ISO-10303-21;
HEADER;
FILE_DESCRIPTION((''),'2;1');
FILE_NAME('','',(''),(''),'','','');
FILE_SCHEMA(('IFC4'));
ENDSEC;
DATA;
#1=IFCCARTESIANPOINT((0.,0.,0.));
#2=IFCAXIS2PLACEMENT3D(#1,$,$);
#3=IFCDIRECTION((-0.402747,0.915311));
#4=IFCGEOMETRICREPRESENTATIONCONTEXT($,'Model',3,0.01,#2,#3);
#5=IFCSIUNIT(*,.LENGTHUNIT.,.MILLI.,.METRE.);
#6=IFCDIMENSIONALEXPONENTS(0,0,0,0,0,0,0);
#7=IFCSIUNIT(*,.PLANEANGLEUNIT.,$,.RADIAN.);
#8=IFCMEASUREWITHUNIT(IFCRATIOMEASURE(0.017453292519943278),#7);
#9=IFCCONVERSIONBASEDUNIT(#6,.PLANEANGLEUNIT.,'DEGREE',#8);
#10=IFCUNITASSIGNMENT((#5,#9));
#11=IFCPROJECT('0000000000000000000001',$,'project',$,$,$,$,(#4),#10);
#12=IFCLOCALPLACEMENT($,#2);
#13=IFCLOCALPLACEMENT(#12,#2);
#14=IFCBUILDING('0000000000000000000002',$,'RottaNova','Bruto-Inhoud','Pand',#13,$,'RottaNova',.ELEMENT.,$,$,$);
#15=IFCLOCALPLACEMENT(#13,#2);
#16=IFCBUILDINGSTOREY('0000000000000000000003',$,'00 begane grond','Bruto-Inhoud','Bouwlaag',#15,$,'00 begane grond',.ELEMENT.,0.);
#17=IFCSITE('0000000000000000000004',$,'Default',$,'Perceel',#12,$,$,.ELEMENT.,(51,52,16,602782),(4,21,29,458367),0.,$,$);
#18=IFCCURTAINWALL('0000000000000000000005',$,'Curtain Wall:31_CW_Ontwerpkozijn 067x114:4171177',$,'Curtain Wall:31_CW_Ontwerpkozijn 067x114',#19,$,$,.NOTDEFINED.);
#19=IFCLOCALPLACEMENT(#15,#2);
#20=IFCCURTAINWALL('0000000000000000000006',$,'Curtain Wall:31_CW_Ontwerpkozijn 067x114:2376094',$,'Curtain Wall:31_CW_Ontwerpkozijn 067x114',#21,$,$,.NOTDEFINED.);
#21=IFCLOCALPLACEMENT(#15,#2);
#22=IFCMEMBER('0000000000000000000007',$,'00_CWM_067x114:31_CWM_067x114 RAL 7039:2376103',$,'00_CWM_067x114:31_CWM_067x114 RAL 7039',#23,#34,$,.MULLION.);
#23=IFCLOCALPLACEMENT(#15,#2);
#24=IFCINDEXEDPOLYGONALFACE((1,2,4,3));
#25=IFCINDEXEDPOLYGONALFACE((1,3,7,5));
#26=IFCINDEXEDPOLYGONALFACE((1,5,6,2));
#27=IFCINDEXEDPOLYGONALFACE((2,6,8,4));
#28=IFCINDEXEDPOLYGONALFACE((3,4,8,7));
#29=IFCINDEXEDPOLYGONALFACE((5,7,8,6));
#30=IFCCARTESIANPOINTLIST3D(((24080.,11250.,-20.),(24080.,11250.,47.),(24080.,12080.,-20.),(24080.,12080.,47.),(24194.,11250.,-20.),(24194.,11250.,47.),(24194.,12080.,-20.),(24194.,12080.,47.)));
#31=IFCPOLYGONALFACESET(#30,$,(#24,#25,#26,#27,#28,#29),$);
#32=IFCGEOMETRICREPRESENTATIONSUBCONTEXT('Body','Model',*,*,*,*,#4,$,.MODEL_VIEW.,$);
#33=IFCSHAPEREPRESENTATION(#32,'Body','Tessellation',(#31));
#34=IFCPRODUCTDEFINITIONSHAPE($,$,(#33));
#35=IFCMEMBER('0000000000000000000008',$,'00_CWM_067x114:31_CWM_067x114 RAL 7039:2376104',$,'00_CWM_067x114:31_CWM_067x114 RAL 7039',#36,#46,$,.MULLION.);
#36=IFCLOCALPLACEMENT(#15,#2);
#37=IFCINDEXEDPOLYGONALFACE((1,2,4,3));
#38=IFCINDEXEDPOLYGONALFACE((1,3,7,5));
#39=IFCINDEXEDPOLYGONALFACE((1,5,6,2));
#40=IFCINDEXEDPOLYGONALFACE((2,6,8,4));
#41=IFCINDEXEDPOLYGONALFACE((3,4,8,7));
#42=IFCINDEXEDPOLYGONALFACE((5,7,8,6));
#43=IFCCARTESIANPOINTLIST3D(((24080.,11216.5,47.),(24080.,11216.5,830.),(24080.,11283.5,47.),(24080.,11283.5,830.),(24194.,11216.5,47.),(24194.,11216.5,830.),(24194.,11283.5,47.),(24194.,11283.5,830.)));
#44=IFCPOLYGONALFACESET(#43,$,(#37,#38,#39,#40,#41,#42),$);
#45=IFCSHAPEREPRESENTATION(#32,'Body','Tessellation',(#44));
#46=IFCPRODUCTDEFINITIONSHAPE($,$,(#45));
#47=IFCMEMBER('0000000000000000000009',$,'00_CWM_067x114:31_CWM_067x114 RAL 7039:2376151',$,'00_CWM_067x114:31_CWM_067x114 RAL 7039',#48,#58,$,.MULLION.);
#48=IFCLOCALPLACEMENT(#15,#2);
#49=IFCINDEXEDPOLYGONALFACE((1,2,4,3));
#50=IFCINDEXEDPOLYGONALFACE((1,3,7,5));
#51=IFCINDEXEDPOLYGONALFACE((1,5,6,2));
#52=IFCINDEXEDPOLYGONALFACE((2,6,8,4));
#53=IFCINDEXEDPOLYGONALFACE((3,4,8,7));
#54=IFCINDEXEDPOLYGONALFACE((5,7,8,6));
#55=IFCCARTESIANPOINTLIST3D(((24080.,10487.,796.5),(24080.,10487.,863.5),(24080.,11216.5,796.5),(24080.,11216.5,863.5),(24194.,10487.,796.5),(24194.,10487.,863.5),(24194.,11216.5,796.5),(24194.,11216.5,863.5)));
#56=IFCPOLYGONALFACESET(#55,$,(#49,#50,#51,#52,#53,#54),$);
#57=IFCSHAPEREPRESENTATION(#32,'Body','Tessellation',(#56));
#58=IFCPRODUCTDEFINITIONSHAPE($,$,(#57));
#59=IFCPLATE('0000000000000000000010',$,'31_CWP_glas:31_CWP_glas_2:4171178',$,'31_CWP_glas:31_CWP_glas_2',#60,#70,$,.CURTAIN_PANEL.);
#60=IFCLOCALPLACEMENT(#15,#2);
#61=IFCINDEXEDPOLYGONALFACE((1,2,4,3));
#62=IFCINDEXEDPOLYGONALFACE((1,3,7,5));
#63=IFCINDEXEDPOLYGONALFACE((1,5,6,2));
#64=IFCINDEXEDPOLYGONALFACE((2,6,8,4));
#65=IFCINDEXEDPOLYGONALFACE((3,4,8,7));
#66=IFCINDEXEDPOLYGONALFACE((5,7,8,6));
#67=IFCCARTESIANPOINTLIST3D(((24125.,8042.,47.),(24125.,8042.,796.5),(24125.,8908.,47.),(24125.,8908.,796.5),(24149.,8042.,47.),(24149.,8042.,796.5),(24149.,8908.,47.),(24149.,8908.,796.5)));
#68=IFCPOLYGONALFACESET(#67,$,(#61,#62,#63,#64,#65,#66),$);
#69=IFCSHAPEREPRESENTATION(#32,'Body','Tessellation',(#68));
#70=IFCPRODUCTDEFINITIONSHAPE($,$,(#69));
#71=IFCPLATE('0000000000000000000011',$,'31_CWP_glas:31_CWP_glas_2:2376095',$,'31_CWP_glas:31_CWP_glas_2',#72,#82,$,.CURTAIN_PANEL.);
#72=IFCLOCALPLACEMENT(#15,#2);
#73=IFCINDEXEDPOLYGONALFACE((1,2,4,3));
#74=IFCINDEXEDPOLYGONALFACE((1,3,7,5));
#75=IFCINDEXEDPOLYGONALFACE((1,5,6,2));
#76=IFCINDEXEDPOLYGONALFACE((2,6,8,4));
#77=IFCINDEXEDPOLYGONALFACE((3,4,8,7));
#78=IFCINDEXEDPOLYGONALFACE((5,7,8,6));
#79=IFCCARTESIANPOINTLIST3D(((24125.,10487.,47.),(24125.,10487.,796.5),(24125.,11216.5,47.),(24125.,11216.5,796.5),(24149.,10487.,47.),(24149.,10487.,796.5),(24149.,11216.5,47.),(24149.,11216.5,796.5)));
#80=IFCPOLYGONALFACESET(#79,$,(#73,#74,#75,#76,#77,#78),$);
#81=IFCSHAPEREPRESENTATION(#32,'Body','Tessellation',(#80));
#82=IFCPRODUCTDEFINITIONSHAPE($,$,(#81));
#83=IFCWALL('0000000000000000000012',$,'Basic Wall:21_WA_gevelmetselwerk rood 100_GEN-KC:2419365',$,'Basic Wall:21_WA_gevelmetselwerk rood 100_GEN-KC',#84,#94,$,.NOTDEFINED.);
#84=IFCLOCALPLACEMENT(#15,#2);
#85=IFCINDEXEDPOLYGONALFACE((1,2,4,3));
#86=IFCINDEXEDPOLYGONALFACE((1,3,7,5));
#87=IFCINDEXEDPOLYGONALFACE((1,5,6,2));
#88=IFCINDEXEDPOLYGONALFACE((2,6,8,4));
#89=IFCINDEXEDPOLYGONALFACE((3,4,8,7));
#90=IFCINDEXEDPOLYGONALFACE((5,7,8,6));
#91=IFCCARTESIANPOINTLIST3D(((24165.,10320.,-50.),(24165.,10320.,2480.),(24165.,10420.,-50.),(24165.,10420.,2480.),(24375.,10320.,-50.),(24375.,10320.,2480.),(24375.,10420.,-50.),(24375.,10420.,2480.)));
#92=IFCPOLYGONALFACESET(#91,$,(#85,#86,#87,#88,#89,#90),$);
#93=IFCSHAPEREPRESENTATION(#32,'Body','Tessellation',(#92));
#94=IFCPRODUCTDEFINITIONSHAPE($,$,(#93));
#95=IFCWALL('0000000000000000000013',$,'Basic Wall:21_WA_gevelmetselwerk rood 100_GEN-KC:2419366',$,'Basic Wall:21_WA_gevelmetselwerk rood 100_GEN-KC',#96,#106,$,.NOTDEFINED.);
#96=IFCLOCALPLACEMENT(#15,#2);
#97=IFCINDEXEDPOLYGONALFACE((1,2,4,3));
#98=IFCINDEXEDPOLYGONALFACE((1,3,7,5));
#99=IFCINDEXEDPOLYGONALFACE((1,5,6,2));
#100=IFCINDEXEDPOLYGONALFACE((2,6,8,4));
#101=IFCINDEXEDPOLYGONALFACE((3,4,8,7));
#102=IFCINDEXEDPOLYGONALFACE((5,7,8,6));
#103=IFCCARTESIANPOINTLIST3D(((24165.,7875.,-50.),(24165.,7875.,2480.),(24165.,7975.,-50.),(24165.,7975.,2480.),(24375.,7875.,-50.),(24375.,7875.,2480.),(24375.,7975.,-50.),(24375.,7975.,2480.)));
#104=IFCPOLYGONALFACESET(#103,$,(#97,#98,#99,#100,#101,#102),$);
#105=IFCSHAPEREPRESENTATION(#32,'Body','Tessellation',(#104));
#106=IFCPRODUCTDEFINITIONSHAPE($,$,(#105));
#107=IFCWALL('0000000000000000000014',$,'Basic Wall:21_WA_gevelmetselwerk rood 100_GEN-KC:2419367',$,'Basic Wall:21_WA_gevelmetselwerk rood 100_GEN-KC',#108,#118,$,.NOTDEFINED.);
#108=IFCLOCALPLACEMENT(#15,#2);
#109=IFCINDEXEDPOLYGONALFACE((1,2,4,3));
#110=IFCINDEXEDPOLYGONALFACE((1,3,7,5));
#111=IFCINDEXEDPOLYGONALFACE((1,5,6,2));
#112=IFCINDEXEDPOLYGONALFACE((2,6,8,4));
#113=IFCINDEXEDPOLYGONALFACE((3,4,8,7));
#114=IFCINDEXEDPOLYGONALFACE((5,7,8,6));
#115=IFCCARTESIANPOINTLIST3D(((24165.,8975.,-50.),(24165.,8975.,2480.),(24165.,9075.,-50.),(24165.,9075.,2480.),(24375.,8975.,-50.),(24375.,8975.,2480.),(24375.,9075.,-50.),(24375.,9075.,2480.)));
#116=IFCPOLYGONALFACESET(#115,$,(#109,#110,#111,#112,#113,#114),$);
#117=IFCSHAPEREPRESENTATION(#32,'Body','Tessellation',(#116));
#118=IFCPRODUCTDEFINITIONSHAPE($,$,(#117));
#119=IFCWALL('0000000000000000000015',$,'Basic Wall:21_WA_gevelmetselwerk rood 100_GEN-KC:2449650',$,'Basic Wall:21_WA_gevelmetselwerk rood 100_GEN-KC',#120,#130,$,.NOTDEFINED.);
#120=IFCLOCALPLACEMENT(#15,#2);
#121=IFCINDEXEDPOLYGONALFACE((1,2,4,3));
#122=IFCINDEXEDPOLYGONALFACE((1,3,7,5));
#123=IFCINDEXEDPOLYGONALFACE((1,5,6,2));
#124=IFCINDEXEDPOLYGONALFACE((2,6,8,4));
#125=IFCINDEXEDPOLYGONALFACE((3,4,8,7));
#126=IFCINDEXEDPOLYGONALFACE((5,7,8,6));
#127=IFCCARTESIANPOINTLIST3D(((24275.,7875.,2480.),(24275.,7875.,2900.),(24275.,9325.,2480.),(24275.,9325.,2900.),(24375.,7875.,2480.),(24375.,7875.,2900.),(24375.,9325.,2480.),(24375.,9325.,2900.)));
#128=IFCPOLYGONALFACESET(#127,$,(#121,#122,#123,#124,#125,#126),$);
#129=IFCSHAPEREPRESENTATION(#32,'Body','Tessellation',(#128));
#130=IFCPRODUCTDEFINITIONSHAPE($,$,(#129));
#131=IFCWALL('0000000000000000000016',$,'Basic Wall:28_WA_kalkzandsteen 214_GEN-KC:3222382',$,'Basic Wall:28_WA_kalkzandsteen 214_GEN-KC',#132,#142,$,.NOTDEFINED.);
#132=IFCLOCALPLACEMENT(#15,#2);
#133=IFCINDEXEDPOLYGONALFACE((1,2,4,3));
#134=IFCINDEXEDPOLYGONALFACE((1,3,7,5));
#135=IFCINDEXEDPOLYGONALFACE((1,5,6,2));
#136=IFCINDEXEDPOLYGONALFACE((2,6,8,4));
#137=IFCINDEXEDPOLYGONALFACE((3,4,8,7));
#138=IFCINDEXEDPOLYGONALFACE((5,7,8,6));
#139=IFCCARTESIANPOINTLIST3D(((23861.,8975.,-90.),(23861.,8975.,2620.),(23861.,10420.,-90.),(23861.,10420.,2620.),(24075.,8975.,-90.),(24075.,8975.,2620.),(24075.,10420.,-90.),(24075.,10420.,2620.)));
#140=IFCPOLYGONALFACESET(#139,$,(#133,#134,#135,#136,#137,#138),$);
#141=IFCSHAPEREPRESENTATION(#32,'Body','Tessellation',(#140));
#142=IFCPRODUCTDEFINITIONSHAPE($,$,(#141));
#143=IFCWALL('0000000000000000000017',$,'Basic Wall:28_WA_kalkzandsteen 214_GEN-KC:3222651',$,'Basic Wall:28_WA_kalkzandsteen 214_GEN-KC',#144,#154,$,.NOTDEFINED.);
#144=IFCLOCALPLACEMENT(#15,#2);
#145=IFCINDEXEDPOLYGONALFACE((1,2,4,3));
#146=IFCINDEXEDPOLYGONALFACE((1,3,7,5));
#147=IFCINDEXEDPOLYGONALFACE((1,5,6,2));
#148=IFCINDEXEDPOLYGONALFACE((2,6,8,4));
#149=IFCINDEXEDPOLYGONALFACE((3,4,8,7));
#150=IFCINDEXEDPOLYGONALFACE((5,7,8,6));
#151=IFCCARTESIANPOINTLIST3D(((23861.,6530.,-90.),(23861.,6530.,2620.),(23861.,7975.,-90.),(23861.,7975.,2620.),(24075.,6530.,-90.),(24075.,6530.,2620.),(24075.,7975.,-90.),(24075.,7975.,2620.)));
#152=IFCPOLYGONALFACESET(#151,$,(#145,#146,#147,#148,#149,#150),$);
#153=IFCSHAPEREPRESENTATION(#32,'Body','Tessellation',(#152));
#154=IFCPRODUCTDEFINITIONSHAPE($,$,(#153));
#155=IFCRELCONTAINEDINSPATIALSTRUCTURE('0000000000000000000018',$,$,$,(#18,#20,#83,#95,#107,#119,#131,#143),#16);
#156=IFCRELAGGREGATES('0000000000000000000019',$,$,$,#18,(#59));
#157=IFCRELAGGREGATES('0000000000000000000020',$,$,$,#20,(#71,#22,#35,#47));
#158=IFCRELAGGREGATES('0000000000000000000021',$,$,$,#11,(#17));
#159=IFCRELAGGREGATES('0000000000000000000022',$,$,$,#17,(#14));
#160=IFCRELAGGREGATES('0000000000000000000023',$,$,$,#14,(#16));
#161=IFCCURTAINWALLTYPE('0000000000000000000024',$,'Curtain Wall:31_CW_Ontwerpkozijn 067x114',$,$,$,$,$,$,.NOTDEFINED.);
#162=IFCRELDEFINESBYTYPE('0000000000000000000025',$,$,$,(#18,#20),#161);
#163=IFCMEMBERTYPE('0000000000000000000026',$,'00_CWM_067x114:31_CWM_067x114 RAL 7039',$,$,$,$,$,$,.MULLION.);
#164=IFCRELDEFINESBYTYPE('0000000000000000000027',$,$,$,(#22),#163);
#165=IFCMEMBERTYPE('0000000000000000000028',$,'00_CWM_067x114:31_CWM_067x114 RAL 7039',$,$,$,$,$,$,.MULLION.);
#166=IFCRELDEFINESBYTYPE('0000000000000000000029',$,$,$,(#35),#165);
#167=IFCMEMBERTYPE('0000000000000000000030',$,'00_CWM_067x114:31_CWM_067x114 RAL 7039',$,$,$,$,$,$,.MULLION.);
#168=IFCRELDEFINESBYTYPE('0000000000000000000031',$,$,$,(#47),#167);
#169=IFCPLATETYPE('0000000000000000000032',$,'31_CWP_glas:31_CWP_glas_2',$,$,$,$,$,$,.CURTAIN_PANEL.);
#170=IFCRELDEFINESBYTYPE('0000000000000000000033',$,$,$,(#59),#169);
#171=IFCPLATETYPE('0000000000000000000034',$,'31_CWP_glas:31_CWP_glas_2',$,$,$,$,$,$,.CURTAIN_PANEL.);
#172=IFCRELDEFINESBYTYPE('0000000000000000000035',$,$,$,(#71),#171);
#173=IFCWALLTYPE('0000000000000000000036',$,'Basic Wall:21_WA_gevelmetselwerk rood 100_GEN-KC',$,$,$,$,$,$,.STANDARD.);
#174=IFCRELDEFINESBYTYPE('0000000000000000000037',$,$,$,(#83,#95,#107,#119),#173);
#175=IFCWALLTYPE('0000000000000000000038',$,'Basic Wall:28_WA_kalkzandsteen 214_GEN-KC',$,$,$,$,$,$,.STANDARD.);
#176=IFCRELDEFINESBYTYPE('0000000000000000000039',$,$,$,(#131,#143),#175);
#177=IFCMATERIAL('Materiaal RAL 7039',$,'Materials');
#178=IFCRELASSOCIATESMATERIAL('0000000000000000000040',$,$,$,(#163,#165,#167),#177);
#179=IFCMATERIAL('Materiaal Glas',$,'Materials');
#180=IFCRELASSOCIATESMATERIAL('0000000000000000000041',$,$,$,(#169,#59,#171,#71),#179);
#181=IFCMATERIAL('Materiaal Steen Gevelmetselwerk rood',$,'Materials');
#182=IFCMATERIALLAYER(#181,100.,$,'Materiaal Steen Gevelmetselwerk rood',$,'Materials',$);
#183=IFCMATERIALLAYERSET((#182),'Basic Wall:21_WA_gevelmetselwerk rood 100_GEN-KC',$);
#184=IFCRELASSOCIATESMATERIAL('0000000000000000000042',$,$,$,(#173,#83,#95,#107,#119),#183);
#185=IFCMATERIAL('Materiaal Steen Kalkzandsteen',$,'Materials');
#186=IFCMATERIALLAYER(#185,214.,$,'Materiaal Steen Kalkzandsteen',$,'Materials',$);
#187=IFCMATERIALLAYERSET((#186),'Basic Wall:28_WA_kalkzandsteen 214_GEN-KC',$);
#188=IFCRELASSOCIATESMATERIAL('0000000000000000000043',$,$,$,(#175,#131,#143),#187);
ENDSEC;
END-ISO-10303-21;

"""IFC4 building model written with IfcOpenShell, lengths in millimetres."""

from ifc_helpers import new_model, entity, si_unit, converted_unit, direction, frame, frame_2d, origin, origin_2d_with_axis, place, context, subcontext, project, spatial, rectangle, extrude, source, transform, mapped, material, layer, layer_set, material_profile, profile_set, type_object, type_shapes, element, aggregate, save


model = new_model("IFC4")

# Units and contexts
model_context = context("Model", 3, precision=0.01, world=origin(), true_north=direction((-0.402747, 0.915311)))
body_context = subcontext(model_context, "Body", "Model", "MODEL_VIEW")
ifc_project = project(units=[si_unit("LENGTHUNIT", "METRE", prefix="MILLI"), converted_unit("PLANEANGLEUNIT", "DEGREE", entity("IfcRatioMeasure", 0.017453292519943278), si_unit("PLANEANGLEUNIT", "RADIAN"), dimensions=[0, 0, 0, 0, 0, 0, 0])], contexts=[model_context])

# Site, building, storey
site_placement = place(None, origin())
site = spatial("IfcSite", under=ifc_project, at=site_placement, Name="Default", ObjectType="Perceel", CompositionType="ELEMENT", RefLatitude=(51, 52, 16, 602782), RefLongitude=(4, 21, 29, 458367), RefElevation=0.0)
building_placement = place(site_placement, origin())
building = spatial("IfcBuilding", under=site, at=building_placement, Name="RottaNova", Description="Bruto-Inhoud", ObjectType="Pand", LongName="RottaNova", CompositionType="ELEMENT")
storey_placement = place(building_placement, origin())
storey = spatial("IfcBuildingStorey", under=building, at=storey_placement, Name="00 begane grond", Description="Bruto-Inhoud", ObjectType="Bouwlaag", LongName="00 begane grond", CompositionType="ELEMENT", Elevation=0.0)

# Curtain wall
curtain_wall_type = type_object("IfcCurtainWallType", Name="Curtain Wall:31_CW_Ontwerpkozijn 067x114", PredefinedType="NOTDEFINED")
curtain_wall_1_placement = place(storey_placement, origin())
curtain_wall_1 = element("IfcCurtainWall", 1, at=curtain_wall_1_placement, inside=storey, type_object=curtain_wall_type, Name="Curtain Wall:31_CW_Ontwerpkozijn 067x114:4171177", ObjectType="Curtain Wall:31_CW_Ontwerpkozijn 067x114", PredefinedType="NOTDEFINED")
ifc_material_1 = material(Name="Materiaal RAL 7039", Category="Materials")
ifc_material_profile = material_profile(ifc_material_1, rectangle(XDim=114.0, YDim=67.0, at=origin_2d_with_axis()), Name="31_CWM_067x114 RAL 7039")
ifc_profile_set = profile_set([ifc_material_profile], Name="31_CWM_067x114 RAL 7039")

# Curtain wall
curtain_wall_2_placement = place(storey_placement, origin())
curtain_wall_2 = element("IfcCurtainWall", 2, at=curtain_wall_2_placement, inside=storey, type_object=curtain_wall_type, Name="Curtain Wall:31_CW_Ontwerpkozijn 067x114:2376094", ObjectType="Curtain Wall:31_CW_Ontwerpkozijn 067x114", PredefinedType="NOTDEFINED")

# Members
member_type_1 = type_object("IfcMemberType", Name="00_CWM_067x114:31_CWM_067x114 RAL 7039", PredefinedType="MULLION", material=ifc_profile_set)
shared_shape_1 = source(origin(), body_context, "Body", "SweptSolid", [
    extrude(rectangle(XDim=114.0, YDim=67.0, at=origin_2d_with_axis()), frame((-33.5, 57.0, -830.0), z_axis=(0.0, 0.0, 1.0), x_axis=(0.0, -1.0, 0.0)), (0.0, 0.0, 1.0), 830.0),
])
type_shapes(member_type_1, [shared_shape_1])
member_1_placement = place(curtain_wall_2_placement, frame((24080.0, 11250.0, -20.0), z_axis=(0.0, -1.0, 0.0), x_axis=(0.0, 0.0, -1.0)))
member_1 = element("IfcMember", 3, at=member_1_placement, type_object=member_type_1, Name="00_CWM_067x114:31_CWM_067x114 RAL 7039:2376103", ObjectType="00_CWM_067x114:31_CWM_067x114 RAL 7039", PredefinedType="MULLION", context=body_context, shape_type="MappedRepresentation", body=[
    mapped(shared_shape_1, transform((0.0, 0.0, 0.0), scale=1.0)),
])
member_type_2 = type_object("IfcMemberType", Name="00_CWM_067x114:31_CWM_067x114 RAL 7039", PredefinedType="MULLION", material=ifc_profile_set)
shared_shape_2 = source(origin(), body_context, "Body", "SweptSolid", [
    extrude(rectangle(XDim=114.0, YDim=67.0, at=origin_2d_with_axis()), frame((0.0, 57.0, -783.0), z_axis=(0.0, 0.0, 1.0), x_axis=(0.0, -1.0, 0.0)), (0.0, 0.0, 1.0), 783.0),
])
type_shapes(member_type_2, [shared_shape_2])
member_2_placement = place(curtain_wall_2_placement, frame((24080.0, 11250.0, 47.0), z_axis=(0.0, 0.0, -1.0), x_axis=(0.0, 1.0, 0.0)))
member_2 = element("IfcMember", 4, at=member_2_placement, type_object=member_type_2, Name="00_CWM_067x114:31_CWM_067x114 RAL 7039:2376104", ObjectType="00_CWM_067x114:31_CWM_067x114 RAL 7039", PredefinedType="MULLION", context=body_context, shape_type="MappedRepresentation", body=[
    mapped(shared_shape_2, transform((0.0, 0.0, 0.0), scale=1.0)),
])
member_type_3 = type_object("IfcMemberType", Name="00_CWM_067x114:31_CWM_067x114 RAL 7039", PredefinedType="MULLION", material=ifc_profile_set)
shared_shape_3 = source(origin(), body_context, "Body", "SweptSolid", [
    extrude(rectangle(XDim=114.0, YDim=67.0, at=origin_2d_with_axis()), frame((0.0, 57.0, -729.5), z_axis=(0.0, 0.0, 1.0), x_axis=(0.0, -1.0, 0.0)), (0.0, 0.0, 1.0), 729.5),
])
type_shapes(member_type_3, [shared_shape_3])
member_3_placement = place(curtain_wall_2_placement, frame((24080.0, 11216.5, 830.0), z_axis=(0.0, 1.0, 0.0), x_axis=(0.0, 0.0, 1.0)))
member_3 = element("IfcMember", 5, at=member_3_placement, type_object=member_type_3, Name="00_CWM_067x114:31_CWM_067x114 RAL 7039:2376151", ObjectType="00_CWM_067x114:31_CWM_067x114 RAL 7039", PredefinedType="MULLION", context=body_context, shape_type="MappedRepresentation", body=[
    mapped(shared_shape_3, transform((0.0, 0.0, 0.0), scale=1.0)),
])

# Plates
ifc_material_2 = material(Name="Materiaal Glas", Category="Materials")
plate_type_1 = type_object("IfcPlateType", Name="31_CWP_glas:31_CWP_glas_2", PredefinedType="CURTAIN_PANEL", material=ifc_material_2)
shared_shape_4 = source(origin(), body_context, "Body", "SweptSolid", [
    extrude(rectangle(XDim=24.0, YDim=866.0, at=frame_2d((0.0, 0.0), x_axis=(1.0, 0.0))), frame((433.0, 12.0, 0.0), z_axis=(0.0, 0.0, 1.0), x_axis=(0.0, 1.0, 0.0)), (0.0, 0.0, 1.0), 749.5),
])
type_shapes(plate_type_1, [shared_shape_4])
plate_1_placement = place(curtain_wall_1_placement, frame((24125.0, 8908.0, 47.0), z_axis=(0.0, 0.0, 1.0), x_axis=(0.0, -1.0, 0.0)))
plate_1 = element("IfcPlate", 6, at=plate_1_placement, type_object=plate_type_1, material=ifc_material_2, Name="31_CWP_glas:31_CWP_glas_2:4171178", ObjectType="31_CWP_glas:31_CWP_glas_2", PredefinedType="CURTAIN_PANEL", context=body_context, shape_type="MappedRepresentation", body=[
    mapped(shared_shape_4, transform((0.0, 0.0, 0.0), scale=1.0)),
])
plate_type_2 = type_object("IfcPlateType", Name="31_CWP_glas:31_CWP_glas_2", PredefinedType="CURTAIN_PANEL", material=ifc_material_2)
shared_shape_5 = source(origin(), body_context, "Body", "SweptSolid", [
    extrude(rectangle(XDim=24.0, YDim=729.5, at=frame_2d((0.0, 0.0), x_axis=(1.0, 0.0))), frame((364.7, 12.0, 0.0), z_axis=(0.0, 0.0, 1.0), x_axis=(0.0, 1.0, 0.0)), (0.0, 0.0, 1.0), 749.5),
])
type_shapes(plate_type_2, [shared_shape_5])
plate_2_placement = place(curtain_wall_2_placement, frame((24149.0, 10487.0, 47.0), z_axis=(0.0, 0.0, 1.0), x_axis=(0.0, 1.0, 0.0)))
plate_2 = element("IfcPlate", 7, at=plate_2_placement, type_object=plate_type_2, material=ifc_material_2, Name="31_CWP_glas:31_CWP_glas_2:2376095", ObjectType="31_CWP_glas:31_CWP_glas_2", PredefinedType="CURTAIN_PANEL", context=body_context, shape_type="MappedRepresentation", body=[
    mapped(shared_shape_5, transform((0.0, 0.0, 0.0), scale=1.0)),
])

# Shared definitions
ifc_material_3 = material(Name="Materiaal Steen Gevelmetselwerk rood", Category="Materials")
ifc_layer_1 = layer(ifc_material_3, 100.0, Name="Materiaal Steen Gevelmetselwerk rood", Category="Materials")
ifc_layer_set_1 = layer_set([ifc_layer_1], Name="Basic Wall:21_WA_gevelmetselwerk rood 100_GEN-KC")
wall_type_1 = type_object("IfcWallType", Name="Basic Wall:21_WA_gevelmetselwerk rood 100_GEN-KC", PredefinedType="STANDARD", material=ifc_layer_set_1)

# Walls
wall_1_placement = place(storey_placement, frame((24375.0, 10370.0, -50.0), z_axis=(0.0, 0.0, 1.0), x_axis=(-1.0, 0.0, 0.0)))
element("IfcWall", 8, at=wall_1_placement, inside=storey, type_object=wall_type_1, material=ifc_layer_set_1, Name="Basic Wall:21_WA_gevelmetselwerk rood 100_GEN-KC:2419365", ObjectType="Basic Wall:21_WA_gevelmetselwerk rood 100_GEN-KC", PredefinedType="NOTDEFINED", context=body_context, shape_type="SweptSolid", body=[
    extrude(rectangle(XDim=210.0, YDim=100.0, at=frame_2d((105.0, 0.0), x_axis=(-1.0, 0.0))), origin(), (0.0, 0.0, 1.0), 2530.0),
])
wall_2_placement = place(storey_placement, frame((24375.0, 7925.0, -50.0), z_axis=(0.0, 0.0, 1.0), x_axis=(-1.0, 0.0, 0.0)))
element("IfcWall", 9, at=wall_2_placement, inside=storey, type_object=wall_type_1, material=ifc_layer_set_1, Name="Basic Wall:21_WA_gevelmetselwerk rood 100_GEN-KC:2419366", ObjectType="Basic Wall:21_WA_gevelmetselwerk rood 100_GEN-KC", PredefinedType="NOTDEFINED", context=body_context, shape_type="SweptSolid", body=[
    extrude(rectangle(XDim=210.0, YDim=100.0, at=frame_2d((105.0, 0.0), x_axis=(-1.0, 0.0))), origin(), (0.0, 0.0, 1.0), 2530.0),
])
wall_3_placement = place(storey_placement, frame((24375.0, 9025.0, -50.0), z_axis=(0.0, 0.0, 1.0), x_axis=(-1.0, 0.0, 0.0)))
element("IfcWall", 10, at=wall_3_placement, inside=storey, type_object=wall_type_1, material=ifc_layer_set_1, Name="Basic Wall:21_WA_gevelmetselwerk rood 100_GEN-KC:2419367", ObjectType="Basic Wall:21_WA_gevelmetselwerk rood 100_GEN-KC", PredefinedType="NOTDEFINED", context=body_context, shape_type="SweptSolid", body=[
    extrude(rectangle(XDim=210.0, YDim=100.0, at=frame_2d((105.0, 0.0), x_axis=(-1.0, 0.0))), origin(), (0.0, 0.0, 1.0), 2530.0),
])
wall_4_placement = place(storey_placement, frame((24325.0, 7875.0, 2480.0), z_axis=(0.0, 0.0, 1.0), x_axis=(0.0, 1.0, 0.0)))
element("IfcWall", 11, at=wall_4_placement, inside=storey, type_object=wall_type_1, material=ifc_layer_set_1, Name="Basic Wall:21_WA_gevelmetselwerk rood 100_GEN-KC:2449650", ObjectType="Basic Wall:21_WA_gevelmetselwerk rood 100_GEN-KC", PredefinedType="NOTDEFINED", context=body_context, shape_type="SweptSolid", body=[
    extrude(rectangle(XDim=1450.0, YDim=100.0, at=frame_2d((725.0, 0.0), x_axis=(-1.0, 0.0))), origin(), (0.0, 0.0, 1.0), 420.0),
])
ifc_material_4 = material(Name="Materiaal Steen Kalkzandsteen", Category="Materials")
ifc_layer_2 = layer(ifc_material_4, 214.0, Name="Materiaal Steen Kalkzandsteen", Category="Materials")
ifc_layer_set_2 = layer_set([ifc_layer_2], Name="Basic Wall:28_WA_kalkzandsteen 214_GEN-KC")
wall_type_2 = type_object("IfcWallType", Name="Basic Wall:28_WA_kalkzandsteen 214_GEN-KC", PredefinedType="STANDARD", material=ifc_layer_set_2)
wall_5_placement = place(storey_placement, frame((23968.0, 10420.0, -90.0), z_axis=(0.0, 0.0, 1.0), x_axis=(0.0, -1.0, 0.0)))
element("IfcWall", 12, at=wall_5_placement, inside=storey, type_object=wall_type_2, material=ifc_layer_set_2, Name="Basic Wall:28_WA_kalkzandsteen 214_GEN-KC:3222382", ObjectType="Basic Wall:28_WA_kalkzandsteen 214_GEN-KC", PredefinedType="NOTDEFINED", context=body_context, shape_type="SweptSolid", body=[
    extrude(rectangle(XDim=1445.0, YDim=214.0, at=frame_2d((722.5, 0.0), x_axis=(-1.0, 0.0))), origin(), (0.0, 0.0, 1.0), 2710.0),
])
wall_6_placement = place(storey_placement, frame((23968.0, 7975.0, -90.0), z_axis=(0.0, 0.0, 1.0), x_axis=(0.0, -1.0, 0.0)))
element("IfcWall", 13, at=wall_6_placement, inside=storey, type_object=wall_type_2, material=ifc_layer_set_2, Name="Basic Wall:28_WA_kalkzandsteen 214_GEN-KC:3222651", ObjectType="Basic Wall:28_WA_kalkzandsteen 214_GEN-KC", PredefinedType="NOTDEFINED", context=body_context, shape_type="SweptSolid", body=[
    extrude(rectangle(XDim=1445.0, YDim=214.0, at=frame_2d((722.5, 0.0), x_axis=(-1.0, 0.0))), origin(), (0.0, 0.0, 1.0), 2710.0),
])

aggregate(curtain_wall_1, [plate_1])
aggregate(curtain_wall_2, [plate_2, member_1, member_2, member_3])

save(model, "model.ifc")
